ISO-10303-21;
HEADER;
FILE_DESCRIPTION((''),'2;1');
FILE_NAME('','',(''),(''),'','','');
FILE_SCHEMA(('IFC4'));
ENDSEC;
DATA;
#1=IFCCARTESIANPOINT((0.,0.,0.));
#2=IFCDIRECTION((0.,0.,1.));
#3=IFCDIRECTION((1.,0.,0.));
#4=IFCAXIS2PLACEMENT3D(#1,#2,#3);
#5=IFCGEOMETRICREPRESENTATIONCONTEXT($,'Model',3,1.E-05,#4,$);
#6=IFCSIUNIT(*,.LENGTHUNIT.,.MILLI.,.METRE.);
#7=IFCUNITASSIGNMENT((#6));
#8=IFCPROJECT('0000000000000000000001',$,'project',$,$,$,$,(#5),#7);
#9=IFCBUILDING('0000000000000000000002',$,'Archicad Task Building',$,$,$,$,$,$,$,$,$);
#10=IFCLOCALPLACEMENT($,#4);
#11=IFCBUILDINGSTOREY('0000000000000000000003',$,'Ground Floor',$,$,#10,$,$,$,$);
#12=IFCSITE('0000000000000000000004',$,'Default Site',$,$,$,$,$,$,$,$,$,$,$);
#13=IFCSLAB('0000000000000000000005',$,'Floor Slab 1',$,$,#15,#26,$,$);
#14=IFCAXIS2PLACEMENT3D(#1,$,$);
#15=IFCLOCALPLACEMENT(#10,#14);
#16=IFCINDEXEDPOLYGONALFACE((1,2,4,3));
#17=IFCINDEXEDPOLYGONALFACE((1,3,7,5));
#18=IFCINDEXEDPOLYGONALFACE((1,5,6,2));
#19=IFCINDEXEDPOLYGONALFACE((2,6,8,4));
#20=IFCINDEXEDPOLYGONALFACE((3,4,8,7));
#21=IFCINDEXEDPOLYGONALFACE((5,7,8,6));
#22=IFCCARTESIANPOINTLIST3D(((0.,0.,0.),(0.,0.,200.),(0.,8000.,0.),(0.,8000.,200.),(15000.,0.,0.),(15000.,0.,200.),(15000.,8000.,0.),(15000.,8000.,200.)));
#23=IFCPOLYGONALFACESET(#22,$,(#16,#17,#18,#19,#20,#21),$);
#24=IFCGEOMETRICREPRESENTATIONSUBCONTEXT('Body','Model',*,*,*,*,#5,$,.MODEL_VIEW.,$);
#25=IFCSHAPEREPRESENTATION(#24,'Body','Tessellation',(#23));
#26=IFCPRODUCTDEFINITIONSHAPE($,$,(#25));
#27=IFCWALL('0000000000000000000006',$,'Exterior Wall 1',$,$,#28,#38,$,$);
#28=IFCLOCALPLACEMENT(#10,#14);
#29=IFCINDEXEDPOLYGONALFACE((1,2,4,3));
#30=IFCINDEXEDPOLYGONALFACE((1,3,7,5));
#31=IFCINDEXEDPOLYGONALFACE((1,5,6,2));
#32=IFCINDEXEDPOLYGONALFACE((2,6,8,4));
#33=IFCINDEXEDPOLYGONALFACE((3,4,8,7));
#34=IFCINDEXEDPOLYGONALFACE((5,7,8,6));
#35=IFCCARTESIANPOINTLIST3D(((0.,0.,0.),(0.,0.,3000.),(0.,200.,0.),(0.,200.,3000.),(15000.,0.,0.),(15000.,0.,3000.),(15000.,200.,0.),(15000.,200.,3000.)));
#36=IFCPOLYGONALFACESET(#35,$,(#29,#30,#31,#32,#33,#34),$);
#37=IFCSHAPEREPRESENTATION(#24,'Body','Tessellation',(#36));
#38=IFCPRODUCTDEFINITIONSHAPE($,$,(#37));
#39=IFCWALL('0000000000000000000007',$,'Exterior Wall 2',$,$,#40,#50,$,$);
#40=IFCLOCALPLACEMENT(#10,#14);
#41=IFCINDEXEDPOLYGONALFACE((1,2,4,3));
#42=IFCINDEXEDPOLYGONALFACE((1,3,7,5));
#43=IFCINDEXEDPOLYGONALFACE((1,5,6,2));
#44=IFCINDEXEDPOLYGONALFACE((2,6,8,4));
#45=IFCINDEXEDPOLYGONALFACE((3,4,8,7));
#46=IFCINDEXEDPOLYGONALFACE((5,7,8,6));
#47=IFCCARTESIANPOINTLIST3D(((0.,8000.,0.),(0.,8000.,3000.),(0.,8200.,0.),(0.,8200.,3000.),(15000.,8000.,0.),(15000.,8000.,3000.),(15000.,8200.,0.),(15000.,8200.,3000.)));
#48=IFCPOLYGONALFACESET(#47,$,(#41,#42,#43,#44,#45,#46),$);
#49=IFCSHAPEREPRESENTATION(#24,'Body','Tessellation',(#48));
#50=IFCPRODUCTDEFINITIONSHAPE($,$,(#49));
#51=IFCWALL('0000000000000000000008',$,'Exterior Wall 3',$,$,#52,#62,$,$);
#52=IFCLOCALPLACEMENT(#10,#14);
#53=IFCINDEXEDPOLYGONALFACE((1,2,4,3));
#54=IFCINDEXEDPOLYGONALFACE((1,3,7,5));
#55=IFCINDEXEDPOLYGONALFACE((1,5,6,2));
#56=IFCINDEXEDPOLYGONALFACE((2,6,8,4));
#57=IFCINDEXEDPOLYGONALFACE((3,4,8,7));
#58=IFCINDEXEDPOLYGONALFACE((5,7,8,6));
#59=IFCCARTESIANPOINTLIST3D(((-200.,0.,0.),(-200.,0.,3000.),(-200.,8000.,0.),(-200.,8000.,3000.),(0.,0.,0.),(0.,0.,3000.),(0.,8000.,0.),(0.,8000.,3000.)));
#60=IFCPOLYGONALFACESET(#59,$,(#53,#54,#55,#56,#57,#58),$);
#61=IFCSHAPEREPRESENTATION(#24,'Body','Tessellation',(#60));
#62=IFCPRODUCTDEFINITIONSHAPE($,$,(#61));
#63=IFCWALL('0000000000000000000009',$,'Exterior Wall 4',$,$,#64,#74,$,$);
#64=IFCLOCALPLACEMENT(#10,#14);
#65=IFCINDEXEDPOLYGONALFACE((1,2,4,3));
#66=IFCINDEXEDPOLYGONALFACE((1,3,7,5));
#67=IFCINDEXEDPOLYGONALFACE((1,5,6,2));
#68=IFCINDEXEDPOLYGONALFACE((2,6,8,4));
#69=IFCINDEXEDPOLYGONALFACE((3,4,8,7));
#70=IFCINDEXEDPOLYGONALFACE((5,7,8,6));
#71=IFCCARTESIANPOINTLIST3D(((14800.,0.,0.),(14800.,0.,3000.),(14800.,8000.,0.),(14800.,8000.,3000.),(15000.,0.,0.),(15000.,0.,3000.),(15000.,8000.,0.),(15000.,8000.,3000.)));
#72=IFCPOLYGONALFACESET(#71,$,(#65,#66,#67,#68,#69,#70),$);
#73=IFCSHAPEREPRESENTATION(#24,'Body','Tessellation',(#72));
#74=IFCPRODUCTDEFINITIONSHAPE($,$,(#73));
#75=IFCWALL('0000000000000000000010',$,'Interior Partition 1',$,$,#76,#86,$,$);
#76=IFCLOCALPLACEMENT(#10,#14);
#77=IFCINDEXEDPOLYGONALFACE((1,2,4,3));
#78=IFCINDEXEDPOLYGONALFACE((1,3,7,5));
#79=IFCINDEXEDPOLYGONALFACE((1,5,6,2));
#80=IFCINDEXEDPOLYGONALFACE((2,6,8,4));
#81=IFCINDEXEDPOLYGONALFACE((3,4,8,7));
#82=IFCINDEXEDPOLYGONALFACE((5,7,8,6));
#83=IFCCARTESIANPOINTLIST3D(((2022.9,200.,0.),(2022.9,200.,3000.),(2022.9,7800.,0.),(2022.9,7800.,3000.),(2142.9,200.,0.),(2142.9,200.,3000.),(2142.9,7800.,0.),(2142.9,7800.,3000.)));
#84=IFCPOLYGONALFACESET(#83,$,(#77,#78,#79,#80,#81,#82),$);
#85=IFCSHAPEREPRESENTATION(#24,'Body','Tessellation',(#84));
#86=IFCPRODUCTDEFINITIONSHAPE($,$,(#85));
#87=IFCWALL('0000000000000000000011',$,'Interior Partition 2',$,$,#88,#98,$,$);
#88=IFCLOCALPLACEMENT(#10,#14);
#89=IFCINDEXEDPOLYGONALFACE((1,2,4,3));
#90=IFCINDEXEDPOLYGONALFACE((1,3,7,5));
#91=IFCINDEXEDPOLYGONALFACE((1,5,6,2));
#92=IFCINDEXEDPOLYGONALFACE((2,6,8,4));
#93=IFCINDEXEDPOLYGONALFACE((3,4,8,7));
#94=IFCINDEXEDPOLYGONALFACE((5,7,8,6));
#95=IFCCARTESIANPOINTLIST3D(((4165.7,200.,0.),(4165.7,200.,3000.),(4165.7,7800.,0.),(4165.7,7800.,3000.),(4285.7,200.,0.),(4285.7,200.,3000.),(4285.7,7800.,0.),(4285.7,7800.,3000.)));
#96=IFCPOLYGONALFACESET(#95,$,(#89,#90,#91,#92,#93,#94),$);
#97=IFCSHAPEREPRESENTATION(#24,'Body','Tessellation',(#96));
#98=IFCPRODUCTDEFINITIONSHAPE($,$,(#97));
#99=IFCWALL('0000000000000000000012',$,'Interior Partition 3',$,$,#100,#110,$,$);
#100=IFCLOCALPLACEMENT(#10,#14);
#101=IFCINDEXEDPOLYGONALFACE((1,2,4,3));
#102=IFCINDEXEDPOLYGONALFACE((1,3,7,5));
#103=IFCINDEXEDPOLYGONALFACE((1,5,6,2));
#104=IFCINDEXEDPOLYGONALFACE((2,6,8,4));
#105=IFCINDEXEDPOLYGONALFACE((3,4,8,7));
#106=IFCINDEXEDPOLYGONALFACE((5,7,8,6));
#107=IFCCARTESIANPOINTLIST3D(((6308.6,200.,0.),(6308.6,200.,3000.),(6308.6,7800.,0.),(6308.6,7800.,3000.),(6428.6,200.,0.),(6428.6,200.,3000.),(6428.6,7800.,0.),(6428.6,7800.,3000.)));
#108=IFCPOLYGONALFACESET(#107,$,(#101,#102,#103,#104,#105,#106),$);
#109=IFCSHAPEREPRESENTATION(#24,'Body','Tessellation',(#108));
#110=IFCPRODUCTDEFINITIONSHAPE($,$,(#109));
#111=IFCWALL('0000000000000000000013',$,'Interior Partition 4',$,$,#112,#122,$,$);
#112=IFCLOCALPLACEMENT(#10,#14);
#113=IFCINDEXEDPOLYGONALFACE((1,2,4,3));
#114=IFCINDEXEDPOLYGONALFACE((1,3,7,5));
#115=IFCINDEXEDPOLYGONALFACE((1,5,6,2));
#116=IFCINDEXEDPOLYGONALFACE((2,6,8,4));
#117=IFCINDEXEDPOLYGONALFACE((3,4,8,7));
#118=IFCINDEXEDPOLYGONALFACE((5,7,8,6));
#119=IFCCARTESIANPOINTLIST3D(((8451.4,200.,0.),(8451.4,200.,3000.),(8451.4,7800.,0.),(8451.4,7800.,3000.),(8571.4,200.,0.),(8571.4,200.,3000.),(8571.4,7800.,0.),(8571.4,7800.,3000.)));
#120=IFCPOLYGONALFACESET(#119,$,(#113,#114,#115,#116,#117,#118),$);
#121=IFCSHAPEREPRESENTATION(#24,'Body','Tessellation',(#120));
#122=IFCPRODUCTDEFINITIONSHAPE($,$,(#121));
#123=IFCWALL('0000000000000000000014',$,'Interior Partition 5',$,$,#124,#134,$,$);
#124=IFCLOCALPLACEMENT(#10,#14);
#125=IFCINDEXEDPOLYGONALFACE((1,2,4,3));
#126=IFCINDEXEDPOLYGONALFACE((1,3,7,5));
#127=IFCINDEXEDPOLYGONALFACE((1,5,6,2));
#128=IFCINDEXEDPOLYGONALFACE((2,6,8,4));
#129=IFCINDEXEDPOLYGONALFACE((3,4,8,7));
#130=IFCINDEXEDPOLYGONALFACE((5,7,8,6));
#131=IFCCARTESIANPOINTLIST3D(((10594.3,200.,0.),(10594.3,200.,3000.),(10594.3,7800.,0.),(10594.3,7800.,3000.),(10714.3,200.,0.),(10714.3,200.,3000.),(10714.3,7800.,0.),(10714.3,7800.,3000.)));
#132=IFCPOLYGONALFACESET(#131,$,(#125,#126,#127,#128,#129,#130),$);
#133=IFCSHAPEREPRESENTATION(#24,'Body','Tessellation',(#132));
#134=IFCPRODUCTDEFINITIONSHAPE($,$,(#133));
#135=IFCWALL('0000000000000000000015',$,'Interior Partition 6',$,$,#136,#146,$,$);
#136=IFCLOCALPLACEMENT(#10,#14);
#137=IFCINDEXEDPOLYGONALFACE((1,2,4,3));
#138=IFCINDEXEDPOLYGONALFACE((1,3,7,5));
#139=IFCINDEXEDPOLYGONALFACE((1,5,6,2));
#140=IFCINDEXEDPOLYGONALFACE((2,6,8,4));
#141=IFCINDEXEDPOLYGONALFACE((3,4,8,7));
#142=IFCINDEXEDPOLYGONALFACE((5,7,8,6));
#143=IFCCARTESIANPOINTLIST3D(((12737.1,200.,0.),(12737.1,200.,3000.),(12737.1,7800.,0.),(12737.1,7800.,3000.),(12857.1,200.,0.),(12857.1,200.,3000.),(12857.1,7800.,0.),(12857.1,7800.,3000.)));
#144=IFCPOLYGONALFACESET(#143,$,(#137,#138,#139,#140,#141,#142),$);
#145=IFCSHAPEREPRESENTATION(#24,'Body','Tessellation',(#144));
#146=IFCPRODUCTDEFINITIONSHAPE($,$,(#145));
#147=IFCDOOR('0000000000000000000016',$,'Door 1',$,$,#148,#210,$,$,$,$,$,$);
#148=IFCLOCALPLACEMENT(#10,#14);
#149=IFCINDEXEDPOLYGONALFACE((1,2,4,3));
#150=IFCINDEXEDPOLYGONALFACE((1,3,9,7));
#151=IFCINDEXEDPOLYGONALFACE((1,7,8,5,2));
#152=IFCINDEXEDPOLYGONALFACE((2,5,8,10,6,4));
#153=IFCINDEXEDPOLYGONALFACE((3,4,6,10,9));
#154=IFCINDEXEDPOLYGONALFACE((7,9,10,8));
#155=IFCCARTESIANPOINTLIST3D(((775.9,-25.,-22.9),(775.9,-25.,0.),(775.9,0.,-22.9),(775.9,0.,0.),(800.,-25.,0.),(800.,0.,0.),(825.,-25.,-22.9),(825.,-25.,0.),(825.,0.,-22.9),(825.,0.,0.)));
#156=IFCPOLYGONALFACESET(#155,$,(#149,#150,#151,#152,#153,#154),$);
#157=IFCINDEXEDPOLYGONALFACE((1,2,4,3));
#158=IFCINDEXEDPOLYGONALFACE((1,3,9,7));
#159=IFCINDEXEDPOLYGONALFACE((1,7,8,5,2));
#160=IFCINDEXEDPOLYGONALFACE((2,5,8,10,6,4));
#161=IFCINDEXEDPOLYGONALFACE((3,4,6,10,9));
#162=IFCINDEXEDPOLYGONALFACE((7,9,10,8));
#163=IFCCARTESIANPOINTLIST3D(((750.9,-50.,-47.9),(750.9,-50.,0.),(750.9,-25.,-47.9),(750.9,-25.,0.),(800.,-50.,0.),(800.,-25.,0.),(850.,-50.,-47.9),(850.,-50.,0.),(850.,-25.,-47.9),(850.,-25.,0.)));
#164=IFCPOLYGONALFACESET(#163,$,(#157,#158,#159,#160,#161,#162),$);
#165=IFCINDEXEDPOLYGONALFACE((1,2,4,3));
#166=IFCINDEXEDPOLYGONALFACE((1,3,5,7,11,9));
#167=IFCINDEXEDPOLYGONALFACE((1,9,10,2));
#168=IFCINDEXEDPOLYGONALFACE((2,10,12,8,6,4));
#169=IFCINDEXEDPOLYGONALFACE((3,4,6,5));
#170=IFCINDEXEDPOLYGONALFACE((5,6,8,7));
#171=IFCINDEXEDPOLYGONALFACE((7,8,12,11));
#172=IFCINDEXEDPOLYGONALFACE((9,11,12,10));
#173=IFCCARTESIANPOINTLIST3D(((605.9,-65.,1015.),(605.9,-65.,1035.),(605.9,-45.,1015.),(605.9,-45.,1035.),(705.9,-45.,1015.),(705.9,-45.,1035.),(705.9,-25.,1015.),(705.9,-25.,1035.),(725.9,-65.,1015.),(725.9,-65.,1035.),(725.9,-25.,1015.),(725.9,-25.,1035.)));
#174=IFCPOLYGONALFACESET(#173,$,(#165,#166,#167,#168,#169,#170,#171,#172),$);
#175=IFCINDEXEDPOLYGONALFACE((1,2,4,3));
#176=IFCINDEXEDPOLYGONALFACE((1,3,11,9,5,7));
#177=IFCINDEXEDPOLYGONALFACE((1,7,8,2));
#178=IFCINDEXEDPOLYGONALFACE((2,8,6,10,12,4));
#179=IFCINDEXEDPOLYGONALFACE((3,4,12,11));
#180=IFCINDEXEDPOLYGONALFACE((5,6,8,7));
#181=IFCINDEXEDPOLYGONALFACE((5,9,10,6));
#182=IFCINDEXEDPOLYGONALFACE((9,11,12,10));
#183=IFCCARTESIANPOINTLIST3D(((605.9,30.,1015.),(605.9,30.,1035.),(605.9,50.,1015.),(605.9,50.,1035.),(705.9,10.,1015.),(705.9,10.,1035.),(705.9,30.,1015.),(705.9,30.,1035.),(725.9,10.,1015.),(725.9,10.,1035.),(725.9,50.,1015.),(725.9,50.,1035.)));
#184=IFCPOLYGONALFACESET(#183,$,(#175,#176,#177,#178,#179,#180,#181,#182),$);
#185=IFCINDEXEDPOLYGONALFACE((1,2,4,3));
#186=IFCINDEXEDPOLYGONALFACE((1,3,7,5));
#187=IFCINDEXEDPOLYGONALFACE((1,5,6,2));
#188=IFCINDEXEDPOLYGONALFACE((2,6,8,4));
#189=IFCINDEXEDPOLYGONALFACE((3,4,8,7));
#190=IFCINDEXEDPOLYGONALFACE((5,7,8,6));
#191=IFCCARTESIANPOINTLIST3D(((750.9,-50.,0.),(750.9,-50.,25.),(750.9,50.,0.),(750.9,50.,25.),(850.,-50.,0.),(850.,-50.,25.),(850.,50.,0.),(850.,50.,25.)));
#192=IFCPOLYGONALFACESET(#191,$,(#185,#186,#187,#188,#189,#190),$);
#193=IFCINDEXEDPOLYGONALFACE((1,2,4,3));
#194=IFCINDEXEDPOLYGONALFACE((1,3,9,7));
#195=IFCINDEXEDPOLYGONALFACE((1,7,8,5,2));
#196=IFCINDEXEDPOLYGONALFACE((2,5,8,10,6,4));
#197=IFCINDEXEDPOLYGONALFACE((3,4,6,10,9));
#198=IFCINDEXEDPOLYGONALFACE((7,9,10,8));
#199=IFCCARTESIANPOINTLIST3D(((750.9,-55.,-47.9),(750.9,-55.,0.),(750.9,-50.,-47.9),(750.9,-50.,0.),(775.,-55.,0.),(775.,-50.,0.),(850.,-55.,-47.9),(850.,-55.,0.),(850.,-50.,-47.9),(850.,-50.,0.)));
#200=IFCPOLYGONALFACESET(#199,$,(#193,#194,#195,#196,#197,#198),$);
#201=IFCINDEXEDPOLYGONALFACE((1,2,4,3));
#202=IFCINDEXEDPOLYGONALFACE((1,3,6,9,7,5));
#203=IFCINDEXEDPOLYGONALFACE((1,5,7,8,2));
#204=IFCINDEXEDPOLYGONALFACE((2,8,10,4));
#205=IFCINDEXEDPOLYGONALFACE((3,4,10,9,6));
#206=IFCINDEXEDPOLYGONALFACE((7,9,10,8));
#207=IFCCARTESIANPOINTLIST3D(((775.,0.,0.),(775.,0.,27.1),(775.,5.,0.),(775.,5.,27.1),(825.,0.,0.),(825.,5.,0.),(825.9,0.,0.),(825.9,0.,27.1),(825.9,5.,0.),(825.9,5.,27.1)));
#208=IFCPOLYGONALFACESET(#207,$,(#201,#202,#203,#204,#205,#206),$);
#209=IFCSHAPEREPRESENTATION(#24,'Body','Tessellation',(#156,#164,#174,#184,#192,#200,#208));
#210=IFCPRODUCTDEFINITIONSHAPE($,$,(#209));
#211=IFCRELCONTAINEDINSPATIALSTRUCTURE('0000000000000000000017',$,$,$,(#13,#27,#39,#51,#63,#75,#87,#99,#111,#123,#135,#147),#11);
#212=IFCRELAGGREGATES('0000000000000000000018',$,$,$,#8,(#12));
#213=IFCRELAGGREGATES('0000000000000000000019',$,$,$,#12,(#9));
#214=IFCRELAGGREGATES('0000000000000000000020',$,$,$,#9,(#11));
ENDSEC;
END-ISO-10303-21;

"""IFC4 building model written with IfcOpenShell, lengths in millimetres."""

from ifc_helpers import new_model, si_unit, frame, origin_with_axes, place, context, subcontext, project, spatial, line, indexed_curve, outline, extrude, element, save


model = new_model("IFC4")

# Units and contexts
model_context = context("Model", 3, precision=1e-05, world=origin_with_axes())
body_context = subcontext(model_context, "Body", "Model", "MODEL_VIEW")
ifc_project = project(units=[si_unit("LENGTHUNIT", "METRE", prefix="MILLI")], contexts=[model_context])

# Site, building, storey
site = spatial("IfcSite", under=ifc_project, Name="Default Site")
building = spatial("IfcBuilding", under=site, Name="Archicad Task Building")
storey_placement = place(None, origin_with_axes())
storey = spatial("IfcBuildingStorey", under=building, at=storey_placement, Name="Ground Floor")

# Slab
slab_placement = place(storey_placement, origin_with_axes())
element("IfcSlab", 1, at=slab_placement, inside=storey, Name="Floor Slab 1", context=body_context, shape_type="SweptSolid", body=[
    extrude(outline(indexed_curve([(0.0, 0.0), (15000.0, 0.0), (15000.0, 8000.0), (0.0, 8000.0), (0.0, 0.0)])), None, (0.0, 0.0, 1.0), 200.0),
])

# Walls
for number, where, z_axis, x_axis, name in (
    (2, (0.0, 0.0, 0.0), (0.0, 0.0, 1.0), (1.0, 0.0, 0.0), "Exterior Wall 1"),
    (3, (0.0, 8000.0, 0.0), (0.0, 0.0, 1.0), (1.0, 0.0, 0.0), "Exterior Wall 2"),
):
    element("IfcWall", number, at=place(storey_placement, frame(where, z_axis=z_axis, x_axis=x_axis)), inside=storey, Name=name, context=body_context, shape_type="SweptSolid", body=[
        extrude(outline(indexed_curve([(0.0, 0.0), (0.0, 200.0), (15000.0, 200.0), (15000.0, 0.0), (0.0, 0.0)], self_intersect=False)), origin_with_axes(), (0.0, 0.0, 1.0), 3000.0),
    ])
for number, where, z_axis, x_axis, name in (
    (4, (0.0, 0.0, 0.0), (0.0, 0.0, 1.0), (0.0, 1.0, 0.0), "Exterior Wall 3"),
    (5, (15000.0, 0.0, 0.0), (0.0, 0.0, 1.0), (0.0, 1.0, 0.0), "Exterior Wall 4"),
):
    element("IfcWall", number, at=place(storey_placement, frame(where, z_axis=z_axis, x_axis=x_axis)), inside=storey, Name=name, context=body_context, shape_type="SweptSolid", body=[
        extrude(outline(indexed_curve([(0.0, 0.0), (0.0, 200.0), (8000.0, 200.0), (8000.0, 0.0), (0.0, 0.0)], self_intersect=False)), origin_with_axes(), (0.0, 0.0, 1.0), 3000.0),
    ])
for number, where, z_axis, x_axis, name in (
    (6, (2142.9, 200.0, 0.0), (0.0, 0.0, 1.0), (0.0, 1.0, 0.0), "Interior Partition 1"),
    (7, (4285.7, 200.0, 0.0), (0.0, 0.0, 1.0), (0.0, 1.0, 0.0), "Interior Partition 2"),
    (8, (6428.6, 200.0, 0.0), (0.0, 0.0, 1.0), (0.0, 1.0, 0.0), "Interior Partition 3"),
    (9, (8571.4, 200.0, 0.0), (0.0, 0.0, 1.0), (0.0, 1.0, 0.0), "Interior Partition 4"),
    (10, (10714.3, 200.0, 0.0), (0.0, 0.0, 1.0), (0.0, 1.0, 0.0), "Interior Partition 5"),
    (11, (12857.1, 200.0, 0.0), (0.0, 0.0, 1.0), (0.0, 1.0, 0.0), "Interior Partition 6"),
):
    element("IfcWall", number, at=place(storey_placement, frame(where, z_axis=z_axis, x_axis=x_axis)), inside=storey, Name=name, context=body_context, shape_type="SweptSolid", body=[
        extrude(outline(indexed_curve([(0.0, 0.0), (0.0, 120.0), (7600.0, 120.0), (7600.0, 0.0), (0.0, 0.0)], self_intersect=False)), origin_with_axes(), (0.0, 0.0, 1.0), 3000.0),
    ])

# Door
door_1_placement = place(storey_placement, frame((800.0, -50.0, 0.0), z_axis=(0.0, 0.0, 1.0), x_axis=(1.0, 0.0, 0.0)))
element("IfcDoor", 12, at=door_1_placement, inside=storey, Name="Door 1", context=body_context, shape_type="SweptSolid", body=[
    extrude(outline(indexed_curve([(0.0, 0.0), (0.0, 2.1), (0.9, 2.1), (0.9, 0.0), (-24.1, 0.0), (-24.1, -22.9), (25.0, -22.9), (25.0, 0.0)], segments=[line(1, 2, 3, 4, 5, 6, 7, 8, 1)])), frame((0.0, 25.0, 0.0), z_axis=(0.0, -1.0, 0.0), x_axis=(1.0, 0.0, 0.0)), (0.0, 0.0, -1.0), 25.0),
    extrude(outline(indexed_curve([(0.0, 0.0), (0.0, 2.1), (0.9, 2.1), (0.9, 0.0), (-49.1, 0.0), (-49.1, -47.9), (50.0, -47.9), (50.0, 0.0)], segments=[line(1, 2, 3, 4, 5, 6, 7, 8, 1)])), frame((0.0, 0.0, 0.0), z_axis=(0.0, -1.0, 0.0), x_axis=(1.0, 0.0, 0.0)), (0.0, 0.0, -1.0), 25.0),
    extrude(outline(indexed_curve([(0.0, 0.0), (-49.1, 0.0), (-49.1, 35.0), (0.0, 35.0)], segments=[line(1, 2, 3, 4, 1)])), frame((25.0, 25.0, 25.0), z_axis=(0.0, 0.0, 1.0), x_axis=(1.0, 0.0, 0.0)), (0.0, 0.0, 1.0), -47.9),
    extrude(outline(indexed_curve([(0.0, 0.0), (0.0, -40.0), (-120.0, -40.0), (-120.0, -20.0), (-20.0, -20.0), (-20.0, 0.0)], segments=[line(1, 2, 3, 4, 5, 6, 1)])), frame((-74.1, 25.0, 1015.0), z_axis=(0.0, 0.0, 1.0), x_axis=(1.0, 0.0, 0.0)), (0.0, 0.0, 1.0), 20.0),
    extrude(outline(indexed_curve([(0.0, 0.0), (0.0, 40.0), (-120.0, 40.0), (-120.0, 20.0), (-20.0, 20.0), (-20.0, 0.0)], segments=[line(1, 2, 3, 4, 5, 6, 1)])), frame((-74.1, 60.0, 1015.0), z_axis=(0.0, 0.0, 1.0), x_axis=(1.0, 0.0, 0.0)), (0.0, 0.0, 1.0), 20.0),
    extrude(outline(indexed_curve([(0.0, 0.0), (-99.1, 0.0), (-99.1, 100.0), (0.0, 100.0)], segments=[line(1, 2, 3, 4, 1)])), frame((50.0, 0.0, 0.0), z_axis=(0.0, 0.0, 1.0), x_axis=(1.0, 0.0, 0.0)), (0.0, 0.0, 1.0), 25.0),
    extrude(outline(indexed_curve([(0.0, 0.0), (0.0, 27.1), (50.9, 27.1), (50.9, 0.0), (-24.1, 0.0), (-24.1, -47.9), (75.0, -47.9), (75.0, 0.0)], segments=[line(1, 2, 3, 4, 5, 6, 7, 8, 1)])), frame((-25.0, -5.0, 0.0), z_axis=(0.0, -1.0, 0.0), x_axis=(1.0, 0.0, 0.0)), (0.0, 0.0, -1.0), 5.0),
    extrude(outline(indexed_curve([(0.0, 0.0), (0.0, 27.1), (50.9, 27.1), (50.9, 0.0), (0.9, 0.0), (0.9, -22.9), (50.0, -22.9), (50.0, 0.0)], segments=[line(1, 2, 3, 4, 5, 6, 7, 8, 1)])), frame((-25.0, 50.0, 0.0), z_axis=(0.0, -1.0, 0.0), x_axis=(1.0, 0.0, 0.0)), (0.0, 0.0, -1.0), 5.0),
])

save(model, "model.ifc")
